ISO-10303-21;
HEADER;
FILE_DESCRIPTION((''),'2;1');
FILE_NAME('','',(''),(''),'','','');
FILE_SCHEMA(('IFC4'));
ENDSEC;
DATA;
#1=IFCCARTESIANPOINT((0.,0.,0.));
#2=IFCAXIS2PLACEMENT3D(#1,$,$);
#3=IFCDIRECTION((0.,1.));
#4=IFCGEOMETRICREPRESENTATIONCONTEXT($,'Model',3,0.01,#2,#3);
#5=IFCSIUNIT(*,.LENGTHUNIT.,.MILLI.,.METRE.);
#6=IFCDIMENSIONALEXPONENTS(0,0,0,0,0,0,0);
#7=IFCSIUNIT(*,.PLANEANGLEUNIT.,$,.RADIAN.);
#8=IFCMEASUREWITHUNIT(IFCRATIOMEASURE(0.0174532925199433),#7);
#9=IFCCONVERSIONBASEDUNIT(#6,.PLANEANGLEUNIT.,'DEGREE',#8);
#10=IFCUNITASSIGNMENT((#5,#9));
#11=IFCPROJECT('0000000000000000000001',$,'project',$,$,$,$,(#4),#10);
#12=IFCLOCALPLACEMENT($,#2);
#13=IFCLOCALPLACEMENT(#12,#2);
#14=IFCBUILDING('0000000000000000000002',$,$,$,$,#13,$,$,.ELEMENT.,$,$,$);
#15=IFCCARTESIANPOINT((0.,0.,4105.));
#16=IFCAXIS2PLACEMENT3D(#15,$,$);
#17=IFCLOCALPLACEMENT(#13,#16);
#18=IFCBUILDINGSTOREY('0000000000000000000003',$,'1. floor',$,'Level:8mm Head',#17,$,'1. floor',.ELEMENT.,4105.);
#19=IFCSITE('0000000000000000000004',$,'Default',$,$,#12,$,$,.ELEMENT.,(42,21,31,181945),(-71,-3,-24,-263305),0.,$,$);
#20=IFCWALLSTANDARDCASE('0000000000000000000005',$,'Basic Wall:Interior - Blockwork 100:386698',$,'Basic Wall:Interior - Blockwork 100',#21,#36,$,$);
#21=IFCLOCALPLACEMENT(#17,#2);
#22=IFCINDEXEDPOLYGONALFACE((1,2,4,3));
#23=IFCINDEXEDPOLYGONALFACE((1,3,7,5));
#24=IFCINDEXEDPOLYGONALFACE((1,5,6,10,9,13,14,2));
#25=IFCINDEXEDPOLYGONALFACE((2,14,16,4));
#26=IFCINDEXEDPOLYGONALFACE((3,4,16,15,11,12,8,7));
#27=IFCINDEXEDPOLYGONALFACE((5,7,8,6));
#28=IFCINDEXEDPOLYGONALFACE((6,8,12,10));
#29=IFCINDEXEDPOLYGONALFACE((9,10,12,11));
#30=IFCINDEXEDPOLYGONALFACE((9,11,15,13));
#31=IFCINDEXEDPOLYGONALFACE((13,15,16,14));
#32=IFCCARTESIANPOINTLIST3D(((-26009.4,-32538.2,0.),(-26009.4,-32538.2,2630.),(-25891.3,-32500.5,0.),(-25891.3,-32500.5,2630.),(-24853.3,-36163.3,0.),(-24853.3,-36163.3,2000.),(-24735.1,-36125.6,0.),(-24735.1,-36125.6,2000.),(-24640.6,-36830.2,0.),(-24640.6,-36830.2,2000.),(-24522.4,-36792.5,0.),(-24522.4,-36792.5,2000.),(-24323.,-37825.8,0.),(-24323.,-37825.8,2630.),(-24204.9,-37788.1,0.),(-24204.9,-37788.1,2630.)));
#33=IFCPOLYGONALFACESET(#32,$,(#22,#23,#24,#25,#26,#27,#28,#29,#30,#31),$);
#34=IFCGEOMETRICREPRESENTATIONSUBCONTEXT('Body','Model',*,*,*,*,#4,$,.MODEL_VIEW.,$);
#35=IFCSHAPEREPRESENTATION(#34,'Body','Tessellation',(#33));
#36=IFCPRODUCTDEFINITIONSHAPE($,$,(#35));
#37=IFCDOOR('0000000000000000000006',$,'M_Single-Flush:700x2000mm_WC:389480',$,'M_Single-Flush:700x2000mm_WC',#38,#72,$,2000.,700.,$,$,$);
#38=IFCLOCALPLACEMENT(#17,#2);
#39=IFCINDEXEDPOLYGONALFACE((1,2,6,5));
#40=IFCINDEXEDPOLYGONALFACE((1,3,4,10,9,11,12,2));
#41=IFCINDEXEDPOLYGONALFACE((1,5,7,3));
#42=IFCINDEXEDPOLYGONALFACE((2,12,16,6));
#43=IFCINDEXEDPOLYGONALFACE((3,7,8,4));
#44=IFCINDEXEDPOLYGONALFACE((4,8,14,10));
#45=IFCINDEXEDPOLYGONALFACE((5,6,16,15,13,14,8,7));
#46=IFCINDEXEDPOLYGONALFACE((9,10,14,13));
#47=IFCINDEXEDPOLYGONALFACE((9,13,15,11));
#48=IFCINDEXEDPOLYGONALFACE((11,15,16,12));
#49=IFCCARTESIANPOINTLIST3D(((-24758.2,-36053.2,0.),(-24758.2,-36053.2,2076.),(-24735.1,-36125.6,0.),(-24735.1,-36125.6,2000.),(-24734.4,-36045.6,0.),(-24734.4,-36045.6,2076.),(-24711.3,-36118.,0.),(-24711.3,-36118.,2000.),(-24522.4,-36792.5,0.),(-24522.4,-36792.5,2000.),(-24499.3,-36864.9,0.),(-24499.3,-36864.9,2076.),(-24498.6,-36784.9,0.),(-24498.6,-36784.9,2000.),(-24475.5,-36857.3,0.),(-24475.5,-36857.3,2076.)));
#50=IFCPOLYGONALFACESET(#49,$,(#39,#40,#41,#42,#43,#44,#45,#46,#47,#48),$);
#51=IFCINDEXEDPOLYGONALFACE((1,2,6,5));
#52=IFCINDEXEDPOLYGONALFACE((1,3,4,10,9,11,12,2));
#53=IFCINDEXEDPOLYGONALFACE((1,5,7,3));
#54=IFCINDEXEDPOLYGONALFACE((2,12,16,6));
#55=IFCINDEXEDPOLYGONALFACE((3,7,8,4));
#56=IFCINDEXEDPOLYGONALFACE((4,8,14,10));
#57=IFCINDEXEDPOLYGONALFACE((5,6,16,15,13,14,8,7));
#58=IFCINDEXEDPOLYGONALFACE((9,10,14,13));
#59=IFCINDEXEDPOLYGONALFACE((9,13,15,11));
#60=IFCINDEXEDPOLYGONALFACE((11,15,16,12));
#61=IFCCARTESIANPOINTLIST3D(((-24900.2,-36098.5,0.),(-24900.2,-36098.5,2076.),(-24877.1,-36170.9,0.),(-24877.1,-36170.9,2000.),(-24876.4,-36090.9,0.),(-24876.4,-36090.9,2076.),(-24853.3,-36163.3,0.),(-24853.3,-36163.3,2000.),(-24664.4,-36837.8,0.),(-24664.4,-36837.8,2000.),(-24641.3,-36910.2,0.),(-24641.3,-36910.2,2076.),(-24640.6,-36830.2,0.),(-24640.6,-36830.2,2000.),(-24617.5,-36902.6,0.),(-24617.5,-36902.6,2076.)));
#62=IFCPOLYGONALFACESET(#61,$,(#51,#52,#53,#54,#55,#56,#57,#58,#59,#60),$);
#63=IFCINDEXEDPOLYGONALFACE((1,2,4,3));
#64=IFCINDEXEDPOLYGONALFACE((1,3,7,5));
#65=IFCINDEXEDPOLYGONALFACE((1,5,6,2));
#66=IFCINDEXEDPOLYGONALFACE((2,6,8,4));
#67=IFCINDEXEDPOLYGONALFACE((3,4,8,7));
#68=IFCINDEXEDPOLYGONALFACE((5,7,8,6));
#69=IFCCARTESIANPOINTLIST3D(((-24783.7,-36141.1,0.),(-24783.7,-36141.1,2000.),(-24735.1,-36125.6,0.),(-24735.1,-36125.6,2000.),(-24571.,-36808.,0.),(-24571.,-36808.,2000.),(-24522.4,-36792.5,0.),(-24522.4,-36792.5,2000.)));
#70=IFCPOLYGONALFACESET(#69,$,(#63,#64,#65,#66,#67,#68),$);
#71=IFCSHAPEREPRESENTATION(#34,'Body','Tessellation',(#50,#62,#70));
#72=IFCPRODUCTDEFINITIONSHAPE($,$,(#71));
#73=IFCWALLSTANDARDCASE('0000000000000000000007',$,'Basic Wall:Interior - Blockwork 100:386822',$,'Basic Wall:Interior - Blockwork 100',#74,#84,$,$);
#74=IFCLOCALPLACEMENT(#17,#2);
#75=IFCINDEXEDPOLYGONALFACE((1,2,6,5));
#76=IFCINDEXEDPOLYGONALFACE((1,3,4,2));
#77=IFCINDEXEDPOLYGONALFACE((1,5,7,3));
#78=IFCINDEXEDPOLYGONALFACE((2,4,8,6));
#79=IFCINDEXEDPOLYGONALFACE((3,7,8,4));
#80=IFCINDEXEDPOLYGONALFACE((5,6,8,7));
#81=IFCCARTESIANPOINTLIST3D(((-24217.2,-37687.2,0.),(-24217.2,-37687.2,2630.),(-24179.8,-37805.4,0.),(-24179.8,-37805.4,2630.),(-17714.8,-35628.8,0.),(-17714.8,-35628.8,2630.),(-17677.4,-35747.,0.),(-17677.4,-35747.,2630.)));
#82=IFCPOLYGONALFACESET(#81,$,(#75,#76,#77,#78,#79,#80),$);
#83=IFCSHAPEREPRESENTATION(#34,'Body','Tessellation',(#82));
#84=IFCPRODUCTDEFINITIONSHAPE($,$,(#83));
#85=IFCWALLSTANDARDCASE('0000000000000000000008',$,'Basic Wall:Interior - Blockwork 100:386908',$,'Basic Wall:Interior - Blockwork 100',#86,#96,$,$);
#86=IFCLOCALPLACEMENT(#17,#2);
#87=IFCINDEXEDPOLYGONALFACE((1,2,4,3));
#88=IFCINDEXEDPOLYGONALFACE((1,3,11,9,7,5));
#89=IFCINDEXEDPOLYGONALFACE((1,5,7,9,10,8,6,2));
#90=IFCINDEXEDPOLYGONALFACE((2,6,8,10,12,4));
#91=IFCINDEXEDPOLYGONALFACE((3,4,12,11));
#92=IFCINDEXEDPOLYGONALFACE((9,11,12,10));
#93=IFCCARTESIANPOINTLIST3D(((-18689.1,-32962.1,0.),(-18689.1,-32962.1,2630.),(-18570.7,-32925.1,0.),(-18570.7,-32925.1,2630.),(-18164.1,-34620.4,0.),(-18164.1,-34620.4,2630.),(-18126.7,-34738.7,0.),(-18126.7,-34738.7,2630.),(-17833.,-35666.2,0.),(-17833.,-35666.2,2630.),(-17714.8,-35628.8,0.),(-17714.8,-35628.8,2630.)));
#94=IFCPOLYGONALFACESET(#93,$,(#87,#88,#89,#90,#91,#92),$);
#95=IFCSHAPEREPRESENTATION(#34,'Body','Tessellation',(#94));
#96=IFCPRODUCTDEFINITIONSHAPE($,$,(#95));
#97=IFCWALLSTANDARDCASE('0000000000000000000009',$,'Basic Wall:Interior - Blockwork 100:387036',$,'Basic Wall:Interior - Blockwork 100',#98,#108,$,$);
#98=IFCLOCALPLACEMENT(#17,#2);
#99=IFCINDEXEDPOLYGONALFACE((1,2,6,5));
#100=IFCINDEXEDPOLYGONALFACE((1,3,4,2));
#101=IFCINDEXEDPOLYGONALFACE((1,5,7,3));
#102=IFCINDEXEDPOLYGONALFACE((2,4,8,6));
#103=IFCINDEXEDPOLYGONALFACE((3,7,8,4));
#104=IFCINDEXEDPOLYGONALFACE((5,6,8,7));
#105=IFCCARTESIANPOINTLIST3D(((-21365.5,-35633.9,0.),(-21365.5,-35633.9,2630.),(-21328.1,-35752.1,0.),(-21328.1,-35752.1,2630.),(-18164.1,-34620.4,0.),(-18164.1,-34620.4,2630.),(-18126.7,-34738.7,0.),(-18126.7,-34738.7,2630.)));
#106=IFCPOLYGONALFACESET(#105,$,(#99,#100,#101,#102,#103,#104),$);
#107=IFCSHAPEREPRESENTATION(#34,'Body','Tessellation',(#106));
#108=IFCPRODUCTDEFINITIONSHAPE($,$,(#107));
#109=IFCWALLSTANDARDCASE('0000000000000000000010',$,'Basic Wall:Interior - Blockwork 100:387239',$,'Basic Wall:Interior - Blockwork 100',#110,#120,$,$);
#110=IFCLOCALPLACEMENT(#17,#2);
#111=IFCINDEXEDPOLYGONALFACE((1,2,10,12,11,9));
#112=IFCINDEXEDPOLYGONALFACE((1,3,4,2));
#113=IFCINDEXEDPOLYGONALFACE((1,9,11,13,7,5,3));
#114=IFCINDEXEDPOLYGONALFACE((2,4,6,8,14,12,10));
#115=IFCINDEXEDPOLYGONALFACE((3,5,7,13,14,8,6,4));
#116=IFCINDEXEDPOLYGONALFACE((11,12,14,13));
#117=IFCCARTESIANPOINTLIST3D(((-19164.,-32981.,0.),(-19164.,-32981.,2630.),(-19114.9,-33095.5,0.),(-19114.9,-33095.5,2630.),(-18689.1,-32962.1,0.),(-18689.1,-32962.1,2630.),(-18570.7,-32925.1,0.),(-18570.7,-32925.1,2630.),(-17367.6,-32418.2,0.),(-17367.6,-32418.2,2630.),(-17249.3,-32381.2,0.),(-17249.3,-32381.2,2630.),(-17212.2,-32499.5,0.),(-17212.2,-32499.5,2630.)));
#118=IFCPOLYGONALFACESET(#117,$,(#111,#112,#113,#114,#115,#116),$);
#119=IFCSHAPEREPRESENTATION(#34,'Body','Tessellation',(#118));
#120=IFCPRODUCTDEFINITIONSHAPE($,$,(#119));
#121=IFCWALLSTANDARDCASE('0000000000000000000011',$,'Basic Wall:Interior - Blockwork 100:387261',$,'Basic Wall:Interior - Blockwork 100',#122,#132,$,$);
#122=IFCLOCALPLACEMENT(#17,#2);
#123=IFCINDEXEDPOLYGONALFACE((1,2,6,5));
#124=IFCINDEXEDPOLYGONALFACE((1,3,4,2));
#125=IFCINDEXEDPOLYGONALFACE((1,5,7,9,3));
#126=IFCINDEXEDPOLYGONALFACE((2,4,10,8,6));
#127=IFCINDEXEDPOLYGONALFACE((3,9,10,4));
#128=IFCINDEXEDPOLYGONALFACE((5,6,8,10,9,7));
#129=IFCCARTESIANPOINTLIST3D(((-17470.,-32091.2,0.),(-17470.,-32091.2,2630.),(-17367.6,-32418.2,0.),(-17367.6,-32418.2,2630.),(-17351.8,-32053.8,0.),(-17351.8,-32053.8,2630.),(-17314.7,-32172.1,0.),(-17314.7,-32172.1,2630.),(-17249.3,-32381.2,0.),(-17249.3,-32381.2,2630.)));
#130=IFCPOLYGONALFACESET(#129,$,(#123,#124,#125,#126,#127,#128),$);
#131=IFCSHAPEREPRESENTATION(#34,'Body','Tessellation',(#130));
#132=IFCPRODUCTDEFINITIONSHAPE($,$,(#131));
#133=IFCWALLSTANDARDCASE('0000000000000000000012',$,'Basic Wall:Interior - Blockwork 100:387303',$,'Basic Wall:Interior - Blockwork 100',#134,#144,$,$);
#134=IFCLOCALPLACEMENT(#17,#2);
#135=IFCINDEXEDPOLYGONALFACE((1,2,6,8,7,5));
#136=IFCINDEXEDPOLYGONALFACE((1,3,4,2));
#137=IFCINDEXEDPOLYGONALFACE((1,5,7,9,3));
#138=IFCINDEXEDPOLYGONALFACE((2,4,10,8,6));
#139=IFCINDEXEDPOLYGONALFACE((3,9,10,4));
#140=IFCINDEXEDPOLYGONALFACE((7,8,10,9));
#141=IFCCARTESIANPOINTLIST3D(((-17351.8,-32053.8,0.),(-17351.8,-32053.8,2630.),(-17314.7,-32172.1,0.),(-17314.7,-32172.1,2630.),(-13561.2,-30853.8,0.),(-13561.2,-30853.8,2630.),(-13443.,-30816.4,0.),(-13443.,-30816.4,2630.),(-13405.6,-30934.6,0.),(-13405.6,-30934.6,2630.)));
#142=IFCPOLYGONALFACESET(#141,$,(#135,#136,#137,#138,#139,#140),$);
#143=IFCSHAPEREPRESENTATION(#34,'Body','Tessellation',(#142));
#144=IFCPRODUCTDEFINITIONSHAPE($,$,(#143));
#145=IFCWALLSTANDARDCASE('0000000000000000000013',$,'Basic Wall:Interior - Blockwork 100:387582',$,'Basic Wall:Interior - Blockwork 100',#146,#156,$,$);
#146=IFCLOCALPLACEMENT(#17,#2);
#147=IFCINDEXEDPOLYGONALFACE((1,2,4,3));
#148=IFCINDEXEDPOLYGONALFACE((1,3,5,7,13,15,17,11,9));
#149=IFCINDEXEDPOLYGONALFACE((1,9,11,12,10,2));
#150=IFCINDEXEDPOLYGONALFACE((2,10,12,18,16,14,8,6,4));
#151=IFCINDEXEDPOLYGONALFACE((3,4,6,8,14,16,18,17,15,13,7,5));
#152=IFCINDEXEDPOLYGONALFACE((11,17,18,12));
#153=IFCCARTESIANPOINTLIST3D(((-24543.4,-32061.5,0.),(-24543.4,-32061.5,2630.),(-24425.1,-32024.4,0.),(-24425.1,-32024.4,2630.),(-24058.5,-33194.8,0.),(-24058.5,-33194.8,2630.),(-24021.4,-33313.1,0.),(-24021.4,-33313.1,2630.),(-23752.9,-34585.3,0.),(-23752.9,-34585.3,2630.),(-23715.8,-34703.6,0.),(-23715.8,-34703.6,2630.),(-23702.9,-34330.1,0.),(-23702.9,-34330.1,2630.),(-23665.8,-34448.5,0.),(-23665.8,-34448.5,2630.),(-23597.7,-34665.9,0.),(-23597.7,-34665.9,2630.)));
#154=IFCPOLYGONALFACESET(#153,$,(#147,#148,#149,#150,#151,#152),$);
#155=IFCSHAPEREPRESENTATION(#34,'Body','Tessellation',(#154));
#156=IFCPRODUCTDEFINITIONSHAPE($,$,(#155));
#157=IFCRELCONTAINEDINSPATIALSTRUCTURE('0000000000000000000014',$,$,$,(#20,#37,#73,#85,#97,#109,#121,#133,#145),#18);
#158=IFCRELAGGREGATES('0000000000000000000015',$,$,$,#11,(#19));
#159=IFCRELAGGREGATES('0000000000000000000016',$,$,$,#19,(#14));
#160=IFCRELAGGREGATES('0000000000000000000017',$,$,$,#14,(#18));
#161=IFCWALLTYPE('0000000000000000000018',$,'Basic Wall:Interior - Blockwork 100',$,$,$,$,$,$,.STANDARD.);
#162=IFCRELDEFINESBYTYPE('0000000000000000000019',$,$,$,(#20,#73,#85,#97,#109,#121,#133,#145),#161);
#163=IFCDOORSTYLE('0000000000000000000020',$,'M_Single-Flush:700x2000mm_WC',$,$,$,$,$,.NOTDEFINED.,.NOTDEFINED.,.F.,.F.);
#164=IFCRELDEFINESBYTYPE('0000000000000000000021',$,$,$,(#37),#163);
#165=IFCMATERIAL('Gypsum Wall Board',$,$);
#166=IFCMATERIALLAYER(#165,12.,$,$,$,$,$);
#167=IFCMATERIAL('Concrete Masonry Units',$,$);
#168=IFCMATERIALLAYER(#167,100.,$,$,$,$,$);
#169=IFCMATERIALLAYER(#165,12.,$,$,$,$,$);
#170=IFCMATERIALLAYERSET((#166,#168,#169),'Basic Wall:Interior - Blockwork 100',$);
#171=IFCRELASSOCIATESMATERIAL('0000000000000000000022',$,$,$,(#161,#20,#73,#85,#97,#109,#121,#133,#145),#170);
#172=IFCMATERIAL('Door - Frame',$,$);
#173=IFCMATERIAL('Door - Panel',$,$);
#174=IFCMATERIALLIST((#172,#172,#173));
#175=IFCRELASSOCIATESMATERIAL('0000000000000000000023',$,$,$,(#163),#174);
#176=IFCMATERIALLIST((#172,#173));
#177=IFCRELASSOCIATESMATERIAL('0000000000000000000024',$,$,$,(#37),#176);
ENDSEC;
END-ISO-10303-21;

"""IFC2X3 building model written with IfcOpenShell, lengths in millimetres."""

from ifc_helpers import new_model, entity, si_unit, converted_unit, direction, frame, frame_2d, origin, origin_2d_with_axis, place, context, subcontext, project, spatial, polyline, rectangle, outline, extrude, source, transform, mapped, material, material_list, layer, layer_set, layer_usage, type_object, type_shapes, element, fill, save


model = new_model("IFC2X3")

# Units and contexts
model_context = context("Model", 3, precision=0.01, world=origin(), true_north=direction((0.0, 1.0)))
body_context = subcontext(model_context, "Body", "Model", "MODEL_VIEW")
ifc_project = project(units=[si_unit("LENGTHUNIT", "METRE", prefix="MILLI"), converted_unit("PLANEANGLEUNIT", "DEGREE", entity("IfcRatioMeasure", 0.0174532925199433), si_unit("PLANEANGLEUNIT", "RADIAN"), dimensions=[0, 0, 0, 0, 0, 0, 0])], contexts=[model_context])

# Site, building, storey
site_placement = place(None, origin())
site = spatial("IfcSite", under=ifc_project, at=site_placement, Name="Default", CompositionType="ELEMENT", RefLatitude=(42, 21, 31, 181945), RefLongitude=(-71, -3, -24, -263305), RefElevation=0.0)
building_placement = place(site_placement, origin())
building = spatial("IfcBuilding", under=site, at=building_placement, CompositionType="ELEMENT")
storey_placement = place(building_placement, frame((0.0, 0.0, 4105.0)))
storey = spatial("IfcBuildingStorey", under=building, at=storey_placement, Name="1. floor", ObjectType="Level:8mm Head", LongName="1. floor", CompositionType="ELEMENT", Elevation=4105.0)

# Wall, opening, door
ifc_material_1 = material(Name="Gypsum Wall Board")
ifc_layer_1 = layer(ifc_material_1, 12.0)
ifc_material_2 = material(Name="Concrete Masonry Units")
ifc_layer_2 = layer(ifc_material_2, 100.0)
ifc_layer_3 = layer(ifc_material_1, 12.0)
ifc_layer_set = layer_set([ifc_layer_1, ifc_layer_2, ifc_layer_3], Name="Basic Wall:Interior - Blockwork 100")
ifc_layer_usage_1 = layer_usage(ifc_layer_set, "AXIS2", "NEGATIVE", 62.0)
wall_type = type_object("IfcWallType", Name="Basic Wall:Interior - Blockwork 100", PredefinedType="STANDARD", material=ifc_layer_set)
wall_1_placement = place(storey_placement, frame((-25950.4, -32519.3, 0.0), z_axis=(0.0, 0.0, 1.0), x_axis=(0.303856, -0.952718, 0.0)))
wall_1 = element("IfcWallStandardCase", 1, at=wall_1_placement, inside=storey, type_object=wall_type, material=ifc_layer_usage_1, Name="Basic Wall:Interior - Blockwork 100:386698", ObjectType="Basic Wall:Interior - Blockwork 100", context=body_context, shape_type="SweptSolid", body=[
    extrude(rectangle(XDim=5550.1, YDim=124.0, at=frame_2d((2775.0, 0.0), x_axis=(-1.0, 0.0))), origin(), (0.0, 0.0, 1.0), 2630.0),
])
opening_1_placement = place(wall_1_placement, frame((3805.0, -62.0, 0.0)))
opening_1 = element("IfcOpeningElement", 2, at=opening_1_placement, cuts=wall_1, ObjectType="Opening", context=body_context, shape_type="SweptSolid", body=[
    extrude(rectangle(XDim=700.0, YDim=2000.0, at=frame_2d((1000.0, 350.0), x_axis=(0.0, 1.0))), frame((0.0, 0.0, 0.0), z_axis=(0.0, 1.0, 0.0), x_axis=(0.0, 0.0, 1.0)), (0.0, 0.0, 1.0), 124.0),
])
ifc_material_3 = material(Name="Door - Frame")
ifc_material_4 = material(Name="Door - Panel")
ifc_material_list_1 = material_list([ifc_material_3, ifc_material_4])
ifc_material_list_2 = material_list([ifc_material_3, ifc_material_3, ifc_material_4])
door_style_1 = type_object("IfcDoorStyle", Name="M_Single-Flush:700x2000mm_WC", ConstructionType="NOTDEFINED", OperationType="NOTDEFINED", ParameterTakesPrecedence=False, Sizeable=False, material=ifc_material_list_2)
shared_shape_1 = source(origin(), body_context, "Body", "SweptSolid", [
    extrude(outline(polyline([(-426.0, -1057.0), (426.0, -1057.0), (426.0, 1019.0), (350.0, 1019.0), (350.0, -981.0), (-350.0, -981.0), (-350.0, 1019.0), (-426.0, 1019.0), (-426.0, -1057.0)])), frame((350.0, 124.0, 1019.0), z_axis=(0.0, 1.0, 0.0), x_axis=(1.0, 0.0, 0.0)), (0.0, 0.0, 1.0), 25.0),
    extrude(outline(polyline([(-1057.0, -426.0), (1019.0, -426.0), (1019.0, -350.0), (-981.0, -350.0), (-981.0, 350.0), (1019.0, 350.0), (1019.0, 426.0), (-1057.0, 426.0), (-1057.0, -426.0)])), frame((350.0, -25.0, 1019.0), z_axis=(0.0, 1.0, 0.0), x_axis=(0.0, 0.0, -1.0)), (0.0, 0.0, 1.0), 25.0),
    extrude(rectangle(XDim=51.0, YDim=700.0, at=origin_2d_with_axis()), frame((350.0, 98.5, 0.0), z_axis=(0.0, 0.0, 1.0), x_axis=(0.0, 1.0, 0.0)), (0.0, 0.0, 1.0), 2000.0),
])
type_shapes(door_style_1, [shared_shape_1])
door_1_placement = place(opening_1_placement, origin())
door_1 = element("IfcDoor", 3, at=door_1_placement, inside=storey, type_object=door_style_1, material=ifc_material_list_1, Name="M_Single-Flush:700x2000mm_WC:389480", ObjectType="M_Single-Flush:700x2000mm_WC", OverallHeight=2000.0, OverallWidth=700.0, context=body_context, shape_type="MappedRepresentation", body=[
    mapped(shared_shape_1, transform((0.0, 0.0, 0.0), scale=1.0)),
])
fill(opening_1, door_1)

# Walls
ifc_layer_usage_2 = layer_usage(ifc_layer_set, "AXIS2", "NEGATIVE", 62.0)
wall_2_placement = place(storey_placement, frame((-24198.5, -37746.3, 0.0), z_axis=(0.0, 0.0, 1.0), x_axis=(0.953372, 0.301797, 0.0)))
element("IfcWallStandardCase", 4, at=wall_2_placement, inside=storey, type_object=wall_type, material=ifc_layer_usage_2, Name="Basic Wall:Interior - Blockwork 100:386822", ObjectType="Basic Wall:Interior - Blockwork 100", context=body_context, shape_type="SweptSolid", body=[
    extrude(rectangle(XDim=6820.4, YDim=124.0, at=frame_2d((3410.2, 0.0), x_axis=(-1.0, 0.0))), origin(), (0.0, 0.0, 1.0), 2630.0),
])
ifc_layer_usage_3 = layer_usage(ifc_layer_set, "AXIS2", "NEGATIVE", 62.0)
wall_3_placement = place(storey_placement, frame((-17773.9, -35647.5, 0.0), z_axis=(0.0, 0.0, 1.0), x_axis=(-0.301797, 0.953372, 0.0)))
element("IfcWallStandardCase", 5, at=wall_3_placement, inside=storey, type_object=wall_type, material=ifc_layer_usage_3, Name="Basic Wall:Interior - Blockwork 100:386908", ObjectType="Basic Wall:Interior - Blockwork 100", context=body_context, shape_type="SweptSolid", body=[
    extrude(outline(polyline([(2836.0, -62.0), (2836.4, 62.0), (1096.9, 62.0), (972.9, 62.0), (0.0, 62.0), (0.0, -62.0), (2836.0, -62.0)])), origin(), (0.0, 0.0, 1.0), 2630.0),
])
ifc_layer_usage_4 = layer_usage(ifc_layer_set, "AXIS2", "NEGATIVE", 62.0)
wall_4_placement = place(storey_placement, frame((-18145.4, -34679.6, 0.0), z_axis=(0.0, 0.0, 1.0), x_axis=(-0.953372, -0.301797, 0.0)))
element("IfcWallStandardCase", 6, at=wall_4_placement, inside=storey, type_object=wall_type, material=ifc_layer_usage_4, Name="Basic Wall:Interior - Blockwork 100:387036", ObjectType="Basic Wall:Interior - Blockwork 100", context=body_context, shape_type="SweptSolid", body=[
    extrude(rectangle(XDim=3358.0, YDim=124.0, at=frame_2d((1679.0, 0.0), x_axis=(-1.0, 0.0))), origin(), (0.0, 0.0, 1.0), 2630.0),
])
ifc_layer_usage_5 = layer_usage(ifc_layer_set, "AXIS2", "NEGATIVE", 62.0)
wall_5_placement = place(storey_placement, frame((-19145.5, -33040.1, 0.0), z_axis=(0.0, 0.0, 1.0), x_axis=(0.954277, 0.298924, 0.0)))
element("IfcWallStandardCase", 7, at=wall_5_placement, inside=storey, type_object=wall_type, material=ifc_layer_usage_5, Name="Basic Wall:Interior - Blockwork 100:387239", ObjectType="Basic Wall:Interior - Blockwork 100", context=body_context, shape_type="SweptSolid", body=[
    extrude(outline(polyline([(2006.5, -62.0), (2006.5, 62.0), (1882.5, 62.0), (0.0, 62.0), (12.6, -62.0), (458.9, -62.0), (582.9, -62.0), (2006.5, -62.0)])), origin(), (0.0, 0.0, 1.0), 2630.0),
])
ifc_layer_usage_6 = layer_usage(ifc_layer_set, "AXIS2", "NEGATIVE", 62.0)
wall_6_placement = place(storey_placement, frame((-17308.4, -32399.7, 0.0), z_axis=(0.0, 0.0, 1.0), x_axis=(-0.298924, 0.954277, 0.0)))
element("IfcWallStandardCase", 8, at=wall_6_placement, inside=storey, type_object=wall_type, material=ifc_layer_usage_6, Name="Basic Wall:Interior - Blockwork 100:387261", ObjectType="Basic Wall:Interior - Blockwork 100", context=body_context, shape_type="SweptSolid", body=[
    extrude(outline(polyline([(343.1, -62.0), (342.7, 62.0), (0.0, 62.0), (0.0, -62.0), (219.1, -62.0), (343.1, -62.0)])), origin(), (0.0, 0.0, 1.0), 2630.0),
])
ifc_layer_usage_7 = layer_usage(ifc_layer_set, "AXIS2", "NEGATIVE", 62.0)
wall_7_placement = place(storey_placement, frame((-17333.5, -32113.0, 0.0), z_axis=(0.0, 0.0, 1.0), x_axis=(0.953372, 0.301797, 0.0)))
element("IfcWallStandardCase", 9, at=wall_7_placement, inside=storey, type_object=wall_type, material=ifc_layer_usage_7, Name="Basic Wall:Interior - Blockwork 100:387303", ObjectType="Basic Wall:Interior - Blockwork 100", context=body_context, shape_type="SweptSolid", body=[
    extrude(outline(polyline([(4100.4, -62.0), (4100.4, 62.0), (3976.4, 62.0), (0.4, 62.0), (0.0, -62.0), (4100.4, -62.0)])), origin(), (0.0, 0.0, 1.0), 2630.0),
])
ifc_layer_usage_8 = layer_usage(ifc_layer_set, "AXIS2", "NEGATIVE", 62.0)
wall_8_placement = place(storey_placement, frame((-24484.3, -32043.0, 0.0), z_axis=(0.0, 0.0, 1.0), x_axis=(0.298924, -0.954277, 0.0)))
element("IfcWallStandardCase", 10, at=wall_8_placement, inside=storey, type_object=wall_type, material=ifc_layer_usage_8, Name="Basic Wall:Interior - Blockwork 100:387582", ObjectType="Basic Wall:Interior - Blockwork 100", context=body_context, shape_type="SweptSolid", body=[
    extrude(outline(polyline([(2768.7, -62.0), (2768.1, 62.0), (2540.2, 62.0), (2416.2, 62.0), (1350.4, 62.0), (1226.4, 62.0), (0.0, 62.0), (0.0, -62.0), (2644.7, -62.0), (2768.7, -62.0)])), origin(), (0.0, 0.0, 1.0), 2630.0),
])

save(model, "model.ifc")
